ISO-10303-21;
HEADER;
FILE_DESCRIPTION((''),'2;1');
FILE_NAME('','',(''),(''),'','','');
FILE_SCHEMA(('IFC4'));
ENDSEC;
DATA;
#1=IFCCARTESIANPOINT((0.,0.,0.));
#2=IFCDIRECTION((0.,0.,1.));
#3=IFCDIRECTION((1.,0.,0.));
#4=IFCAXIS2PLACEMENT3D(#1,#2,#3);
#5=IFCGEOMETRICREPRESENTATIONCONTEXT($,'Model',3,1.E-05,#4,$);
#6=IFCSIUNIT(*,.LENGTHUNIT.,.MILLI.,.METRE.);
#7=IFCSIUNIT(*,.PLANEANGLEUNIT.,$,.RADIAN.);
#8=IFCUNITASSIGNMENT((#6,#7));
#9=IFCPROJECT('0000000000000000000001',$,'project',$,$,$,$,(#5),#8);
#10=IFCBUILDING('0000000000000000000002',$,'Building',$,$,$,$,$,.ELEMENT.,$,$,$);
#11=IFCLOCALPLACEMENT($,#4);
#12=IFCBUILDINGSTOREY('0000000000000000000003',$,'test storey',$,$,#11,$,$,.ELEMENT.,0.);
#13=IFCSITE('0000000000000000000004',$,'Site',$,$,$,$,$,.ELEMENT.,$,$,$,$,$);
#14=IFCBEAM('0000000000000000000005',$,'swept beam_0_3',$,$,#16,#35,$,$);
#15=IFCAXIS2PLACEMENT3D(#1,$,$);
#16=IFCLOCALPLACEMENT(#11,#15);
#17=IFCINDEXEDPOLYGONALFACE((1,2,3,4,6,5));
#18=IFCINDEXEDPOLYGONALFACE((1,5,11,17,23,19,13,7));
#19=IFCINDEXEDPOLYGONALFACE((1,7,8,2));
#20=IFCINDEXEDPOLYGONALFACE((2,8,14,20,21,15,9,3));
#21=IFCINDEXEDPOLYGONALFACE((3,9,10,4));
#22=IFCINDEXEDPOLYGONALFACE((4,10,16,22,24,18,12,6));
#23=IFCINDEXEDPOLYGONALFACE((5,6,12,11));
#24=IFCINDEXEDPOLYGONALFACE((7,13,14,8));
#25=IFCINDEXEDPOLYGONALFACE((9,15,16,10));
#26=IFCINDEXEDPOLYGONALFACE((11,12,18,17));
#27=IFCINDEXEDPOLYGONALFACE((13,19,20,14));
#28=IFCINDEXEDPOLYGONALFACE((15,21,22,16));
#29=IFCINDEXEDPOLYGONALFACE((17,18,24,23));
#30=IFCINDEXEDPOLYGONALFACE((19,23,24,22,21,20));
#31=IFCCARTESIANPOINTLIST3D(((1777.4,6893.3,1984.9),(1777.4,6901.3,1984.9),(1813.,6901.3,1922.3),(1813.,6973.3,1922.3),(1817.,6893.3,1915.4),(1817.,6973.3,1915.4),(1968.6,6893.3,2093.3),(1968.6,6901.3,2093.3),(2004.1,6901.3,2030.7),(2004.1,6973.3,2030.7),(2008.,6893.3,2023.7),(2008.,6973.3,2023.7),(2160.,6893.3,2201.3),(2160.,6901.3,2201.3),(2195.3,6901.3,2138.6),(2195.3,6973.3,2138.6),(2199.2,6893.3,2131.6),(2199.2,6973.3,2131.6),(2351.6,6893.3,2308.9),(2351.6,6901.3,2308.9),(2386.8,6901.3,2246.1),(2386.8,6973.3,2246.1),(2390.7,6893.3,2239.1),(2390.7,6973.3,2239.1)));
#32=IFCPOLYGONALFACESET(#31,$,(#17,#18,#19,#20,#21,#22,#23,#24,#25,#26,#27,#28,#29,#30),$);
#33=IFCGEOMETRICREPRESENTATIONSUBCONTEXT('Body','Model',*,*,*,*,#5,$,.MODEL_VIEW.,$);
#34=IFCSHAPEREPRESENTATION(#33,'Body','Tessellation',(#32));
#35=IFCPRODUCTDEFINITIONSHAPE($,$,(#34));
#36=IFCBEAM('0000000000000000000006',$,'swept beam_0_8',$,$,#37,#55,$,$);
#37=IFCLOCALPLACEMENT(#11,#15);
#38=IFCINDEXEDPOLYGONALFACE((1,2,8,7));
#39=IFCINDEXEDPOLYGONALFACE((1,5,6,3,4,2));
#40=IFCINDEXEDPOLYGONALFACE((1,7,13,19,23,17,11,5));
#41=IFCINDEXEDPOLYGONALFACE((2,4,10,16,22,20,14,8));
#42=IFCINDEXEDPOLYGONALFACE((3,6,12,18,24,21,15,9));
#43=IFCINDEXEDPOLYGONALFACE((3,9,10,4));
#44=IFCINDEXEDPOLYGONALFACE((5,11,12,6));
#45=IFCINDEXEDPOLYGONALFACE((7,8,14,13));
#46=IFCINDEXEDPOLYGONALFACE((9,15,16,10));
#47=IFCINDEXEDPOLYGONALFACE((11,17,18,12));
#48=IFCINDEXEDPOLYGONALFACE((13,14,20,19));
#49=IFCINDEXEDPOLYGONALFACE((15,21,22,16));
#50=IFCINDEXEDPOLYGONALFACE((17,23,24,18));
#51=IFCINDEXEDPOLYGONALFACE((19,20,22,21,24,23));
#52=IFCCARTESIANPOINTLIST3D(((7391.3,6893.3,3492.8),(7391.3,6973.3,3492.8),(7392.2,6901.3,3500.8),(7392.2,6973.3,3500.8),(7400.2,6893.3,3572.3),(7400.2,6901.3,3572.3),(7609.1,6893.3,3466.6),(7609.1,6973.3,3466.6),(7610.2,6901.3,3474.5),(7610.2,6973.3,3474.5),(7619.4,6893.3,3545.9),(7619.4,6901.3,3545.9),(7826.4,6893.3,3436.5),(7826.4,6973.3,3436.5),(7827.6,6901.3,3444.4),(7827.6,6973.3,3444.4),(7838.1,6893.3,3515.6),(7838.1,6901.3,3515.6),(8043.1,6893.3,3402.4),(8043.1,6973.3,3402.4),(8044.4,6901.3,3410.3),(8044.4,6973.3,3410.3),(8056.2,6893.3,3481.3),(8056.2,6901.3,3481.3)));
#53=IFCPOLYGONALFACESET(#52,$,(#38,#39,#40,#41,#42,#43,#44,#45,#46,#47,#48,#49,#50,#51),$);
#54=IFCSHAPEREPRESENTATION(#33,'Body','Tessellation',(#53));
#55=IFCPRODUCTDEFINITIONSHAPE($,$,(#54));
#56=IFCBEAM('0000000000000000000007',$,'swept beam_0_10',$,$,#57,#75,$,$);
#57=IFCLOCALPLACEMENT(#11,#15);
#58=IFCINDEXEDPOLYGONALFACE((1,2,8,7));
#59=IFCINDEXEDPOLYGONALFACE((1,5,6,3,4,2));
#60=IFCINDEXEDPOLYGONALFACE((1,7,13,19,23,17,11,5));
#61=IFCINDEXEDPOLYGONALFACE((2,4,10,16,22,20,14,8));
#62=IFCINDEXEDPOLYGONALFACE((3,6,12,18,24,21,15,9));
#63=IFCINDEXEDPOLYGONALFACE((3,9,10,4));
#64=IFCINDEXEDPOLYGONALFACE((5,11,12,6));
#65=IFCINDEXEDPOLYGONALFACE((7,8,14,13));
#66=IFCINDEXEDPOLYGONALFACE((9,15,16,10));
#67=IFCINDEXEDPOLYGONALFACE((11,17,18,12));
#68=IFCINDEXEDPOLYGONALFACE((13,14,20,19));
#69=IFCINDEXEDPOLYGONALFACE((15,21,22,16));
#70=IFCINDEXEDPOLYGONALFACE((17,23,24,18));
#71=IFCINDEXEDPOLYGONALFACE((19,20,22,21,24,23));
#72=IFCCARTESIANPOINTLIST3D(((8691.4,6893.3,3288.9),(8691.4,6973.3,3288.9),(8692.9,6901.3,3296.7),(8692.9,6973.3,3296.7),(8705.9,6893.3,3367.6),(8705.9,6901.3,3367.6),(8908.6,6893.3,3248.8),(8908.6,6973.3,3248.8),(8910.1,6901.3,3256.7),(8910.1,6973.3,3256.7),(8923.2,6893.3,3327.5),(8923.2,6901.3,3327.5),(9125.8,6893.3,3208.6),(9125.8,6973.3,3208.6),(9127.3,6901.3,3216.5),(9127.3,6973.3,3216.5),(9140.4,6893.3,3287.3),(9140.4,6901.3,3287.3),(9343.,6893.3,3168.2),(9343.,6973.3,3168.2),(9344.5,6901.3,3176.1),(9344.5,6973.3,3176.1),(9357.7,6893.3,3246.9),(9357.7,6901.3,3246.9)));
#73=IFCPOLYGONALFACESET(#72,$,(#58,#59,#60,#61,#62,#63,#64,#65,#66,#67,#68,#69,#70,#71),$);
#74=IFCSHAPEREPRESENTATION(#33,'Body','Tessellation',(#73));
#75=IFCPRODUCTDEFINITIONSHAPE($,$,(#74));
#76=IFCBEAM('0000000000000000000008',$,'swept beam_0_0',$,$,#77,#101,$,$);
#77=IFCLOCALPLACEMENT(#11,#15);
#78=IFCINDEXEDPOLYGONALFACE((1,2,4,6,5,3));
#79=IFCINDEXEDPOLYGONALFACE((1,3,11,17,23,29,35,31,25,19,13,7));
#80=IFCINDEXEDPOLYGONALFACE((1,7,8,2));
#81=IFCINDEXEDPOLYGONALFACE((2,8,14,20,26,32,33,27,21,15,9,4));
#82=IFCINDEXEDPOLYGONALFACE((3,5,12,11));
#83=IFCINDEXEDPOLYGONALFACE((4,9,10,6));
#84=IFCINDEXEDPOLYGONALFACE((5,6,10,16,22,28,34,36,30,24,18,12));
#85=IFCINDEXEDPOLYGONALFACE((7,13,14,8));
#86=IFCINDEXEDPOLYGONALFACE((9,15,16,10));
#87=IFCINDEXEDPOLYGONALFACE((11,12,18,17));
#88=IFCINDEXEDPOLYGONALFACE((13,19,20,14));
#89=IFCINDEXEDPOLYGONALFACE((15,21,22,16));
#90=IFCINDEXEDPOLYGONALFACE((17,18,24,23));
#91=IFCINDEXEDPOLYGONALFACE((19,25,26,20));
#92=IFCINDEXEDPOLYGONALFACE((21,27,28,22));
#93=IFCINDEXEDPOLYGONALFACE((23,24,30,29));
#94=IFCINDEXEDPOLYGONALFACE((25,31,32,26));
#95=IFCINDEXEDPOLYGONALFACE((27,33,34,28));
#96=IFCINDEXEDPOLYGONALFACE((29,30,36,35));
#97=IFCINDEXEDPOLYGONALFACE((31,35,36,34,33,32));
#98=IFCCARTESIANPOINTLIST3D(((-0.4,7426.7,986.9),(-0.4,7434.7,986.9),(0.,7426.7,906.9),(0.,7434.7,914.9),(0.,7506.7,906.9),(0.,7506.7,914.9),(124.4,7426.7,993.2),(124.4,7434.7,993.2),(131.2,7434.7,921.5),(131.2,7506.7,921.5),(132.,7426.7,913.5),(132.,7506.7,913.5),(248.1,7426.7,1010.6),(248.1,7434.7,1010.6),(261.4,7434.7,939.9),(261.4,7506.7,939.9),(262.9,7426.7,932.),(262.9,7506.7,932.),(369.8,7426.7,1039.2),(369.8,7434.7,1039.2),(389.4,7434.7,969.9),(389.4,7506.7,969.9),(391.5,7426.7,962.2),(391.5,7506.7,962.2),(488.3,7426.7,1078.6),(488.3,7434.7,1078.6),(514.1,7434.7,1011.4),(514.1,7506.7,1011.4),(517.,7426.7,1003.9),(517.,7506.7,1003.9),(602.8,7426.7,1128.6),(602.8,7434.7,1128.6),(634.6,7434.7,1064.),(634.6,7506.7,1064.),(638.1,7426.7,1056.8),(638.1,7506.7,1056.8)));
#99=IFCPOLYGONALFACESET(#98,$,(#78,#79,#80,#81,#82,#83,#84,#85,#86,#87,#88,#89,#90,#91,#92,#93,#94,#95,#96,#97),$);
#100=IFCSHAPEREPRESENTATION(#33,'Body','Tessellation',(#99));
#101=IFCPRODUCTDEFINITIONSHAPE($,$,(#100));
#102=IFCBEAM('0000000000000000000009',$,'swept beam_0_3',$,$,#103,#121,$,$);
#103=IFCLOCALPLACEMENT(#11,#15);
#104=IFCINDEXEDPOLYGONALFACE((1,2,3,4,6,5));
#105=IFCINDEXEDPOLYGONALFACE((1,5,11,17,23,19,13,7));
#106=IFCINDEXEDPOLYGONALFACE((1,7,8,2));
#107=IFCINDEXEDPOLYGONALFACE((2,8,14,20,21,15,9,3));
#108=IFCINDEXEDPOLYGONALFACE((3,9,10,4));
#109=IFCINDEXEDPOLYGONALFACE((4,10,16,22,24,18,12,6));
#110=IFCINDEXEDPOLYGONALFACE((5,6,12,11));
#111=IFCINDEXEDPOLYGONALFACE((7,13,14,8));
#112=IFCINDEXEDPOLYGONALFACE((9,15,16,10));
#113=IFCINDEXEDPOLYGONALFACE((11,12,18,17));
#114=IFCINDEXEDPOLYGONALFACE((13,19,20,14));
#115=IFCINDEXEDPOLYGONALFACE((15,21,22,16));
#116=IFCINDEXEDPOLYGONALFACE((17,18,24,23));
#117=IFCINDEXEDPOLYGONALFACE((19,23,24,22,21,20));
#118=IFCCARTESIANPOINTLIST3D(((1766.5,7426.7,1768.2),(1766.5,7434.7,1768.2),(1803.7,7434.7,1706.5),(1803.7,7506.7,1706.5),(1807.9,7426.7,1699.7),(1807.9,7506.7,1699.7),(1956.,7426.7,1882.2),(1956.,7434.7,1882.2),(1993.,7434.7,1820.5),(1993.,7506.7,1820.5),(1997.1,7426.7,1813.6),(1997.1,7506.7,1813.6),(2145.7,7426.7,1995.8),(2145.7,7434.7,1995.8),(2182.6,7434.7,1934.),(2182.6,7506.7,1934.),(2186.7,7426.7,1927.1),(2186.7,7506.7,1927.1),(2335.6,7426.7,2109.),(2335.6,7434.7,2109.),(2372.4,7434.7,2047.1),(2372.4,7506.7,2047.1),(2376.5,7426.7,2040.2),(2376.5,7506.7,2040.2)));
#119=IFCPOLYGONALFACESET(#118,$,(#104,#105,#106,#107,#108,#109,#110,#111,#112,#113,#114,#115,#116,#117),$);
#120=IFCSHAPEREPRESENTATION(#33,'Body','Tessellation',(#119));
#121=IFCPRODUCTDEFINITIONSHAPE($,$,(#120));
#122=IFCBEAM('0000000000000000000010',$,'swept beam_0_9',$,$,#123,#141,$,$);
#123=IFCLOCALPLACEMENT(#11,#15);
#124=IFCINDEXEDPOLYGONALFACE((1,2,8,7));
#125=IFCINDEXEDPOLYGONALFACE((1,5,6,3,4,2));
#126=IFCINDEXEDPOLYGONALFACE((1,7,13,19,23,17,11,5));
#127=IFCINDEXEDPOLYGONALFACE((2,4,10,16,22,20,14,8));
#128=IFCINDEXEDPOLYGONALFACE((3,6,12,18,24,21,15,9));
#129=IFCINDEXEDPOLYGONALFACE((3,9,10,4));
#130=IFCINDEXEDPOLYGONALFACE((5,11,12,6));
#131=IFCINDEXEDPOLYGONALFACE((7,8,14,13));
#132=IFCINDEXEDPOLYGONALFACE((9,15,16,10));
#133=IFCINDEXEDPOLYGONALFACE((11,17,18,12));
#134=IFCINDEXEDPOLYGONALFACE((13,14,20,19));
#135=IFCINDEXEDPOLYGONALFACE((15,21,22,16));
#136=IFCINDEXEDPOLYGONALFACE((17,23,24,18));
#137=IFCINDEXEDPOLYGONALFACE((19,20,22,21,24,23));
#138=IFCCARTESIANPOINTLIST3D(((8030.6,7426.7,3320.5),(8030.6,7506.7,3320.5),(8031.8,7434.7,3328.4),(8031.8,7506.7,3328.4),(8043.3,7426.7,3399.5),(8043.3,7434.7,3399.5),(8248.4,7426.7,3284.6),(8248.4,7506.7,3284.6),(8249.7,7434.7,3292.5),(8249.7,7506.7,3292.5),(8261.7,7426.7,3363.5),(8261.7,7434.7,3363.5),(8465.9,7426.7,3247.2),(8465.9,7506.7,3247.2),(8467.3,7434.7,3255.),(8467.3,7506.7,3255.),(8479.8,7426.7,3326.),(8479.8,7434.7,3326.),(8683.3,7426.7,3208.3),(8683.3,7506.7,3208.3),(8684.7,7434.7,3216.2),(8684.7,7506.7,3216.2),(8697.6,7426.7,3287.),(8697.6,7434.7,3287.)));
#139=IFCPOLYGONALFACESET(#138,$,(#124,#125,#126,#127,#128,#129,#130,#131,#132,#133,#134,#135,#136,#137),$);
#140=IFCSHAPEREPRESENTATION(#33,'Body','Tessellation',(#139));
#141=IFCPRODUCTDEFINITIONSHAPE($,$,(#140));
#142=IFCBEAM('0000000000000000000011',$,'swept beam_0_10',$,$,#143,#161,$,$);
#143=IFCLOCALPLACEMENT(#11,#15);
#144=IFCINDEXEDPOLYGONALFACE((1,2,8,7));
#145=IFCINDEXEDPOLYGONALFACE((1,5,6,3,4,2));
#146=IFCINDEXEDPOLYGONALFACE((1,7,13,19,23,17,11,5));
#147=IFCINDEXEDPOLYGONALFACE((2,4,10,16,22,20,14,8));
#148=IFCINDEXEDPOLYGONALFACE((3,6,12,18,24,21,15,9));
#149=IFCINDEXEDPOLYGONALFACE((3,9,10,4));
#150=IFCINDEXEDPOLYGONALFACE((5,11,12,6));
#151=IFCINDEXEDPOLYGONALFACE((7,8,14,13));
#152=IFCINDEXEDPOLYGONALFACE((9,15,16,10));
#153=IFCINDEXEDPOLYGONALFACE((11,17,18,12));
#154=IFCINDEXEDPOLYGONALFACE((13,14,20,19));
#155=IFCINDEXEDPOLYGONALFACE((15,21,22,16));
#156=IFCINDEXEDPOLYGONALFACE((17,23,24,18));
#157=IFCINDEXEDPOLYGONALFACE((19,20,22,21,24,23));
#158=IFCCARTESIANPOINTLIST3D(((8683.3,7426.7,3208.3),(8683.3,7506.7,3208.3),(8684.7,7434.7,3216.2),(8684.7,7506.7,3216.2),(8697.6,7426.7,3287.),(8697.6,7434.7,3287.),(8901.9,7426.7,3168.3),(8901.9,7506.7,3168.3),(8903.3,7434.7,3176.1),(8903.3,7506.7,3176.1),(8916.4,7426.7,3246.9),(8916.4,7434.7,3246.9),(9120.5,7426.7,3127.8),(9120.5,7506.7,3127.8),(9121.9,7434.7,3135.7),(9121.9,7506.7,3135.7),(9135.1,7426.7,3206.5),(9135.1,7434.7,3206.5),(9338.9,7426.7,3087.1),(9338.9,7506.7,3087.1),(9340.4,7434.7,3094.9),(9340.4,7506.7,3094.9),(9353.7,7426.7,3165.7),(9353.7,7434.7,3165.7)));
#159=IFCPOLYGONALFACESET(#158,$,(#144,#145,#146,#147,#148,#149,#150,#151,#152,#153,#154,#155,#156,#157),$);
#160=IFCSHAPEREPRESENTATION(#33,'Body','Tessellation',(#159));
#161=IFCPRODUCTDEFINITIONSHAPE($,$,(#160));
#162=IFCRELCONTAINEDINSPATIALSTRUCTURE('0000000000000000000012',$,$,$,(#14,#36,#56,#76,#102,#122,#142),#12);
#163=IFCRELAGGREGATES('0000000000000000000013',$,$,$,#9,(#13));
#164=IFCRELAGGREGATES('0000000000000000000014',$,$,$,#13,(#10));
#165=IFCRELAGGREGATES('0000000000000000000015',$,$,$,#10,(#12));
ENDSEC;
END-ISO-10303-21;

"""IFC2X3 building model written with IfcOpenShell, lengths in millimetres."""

from ifc_helpers import new_model, entity, si_unit, origin_with_axes, place, context, subcontext, project, spatial, element, save


model = new_model("IFC2X3")

# Units and contexts
model_context = context("Model", 3, precision=1e-05, world=origin_with_axes())
body_context = subcontext(model_context, "Body", "Model", "MODEL_VIEW")
ifc_project = project(units=[si_unit("LENGTHUNIT", "METRE", prefix="MILLI"), si_unit("PLANEANGLEUNIT", "RADIAN")], contexts=[model_context])

# Site, building, storey
site = spatial("IfcSite", under=ifc_project, Name="Site", CompositionType="ELEMENT")
building = spatial("IfcBuilding", under=site, Name="Building", CompositionType="ELEMENT")
storey_placement = place(None, origin_with_axes())
storey = spatial("IfcBuildingStorey", under=building, at=storey_placement, Name="test storey", CompositionType="ELEMENT", Elevation=0.0)

# Beams
beam_1_placement = place(storey_placement, origin_with_axes())
element("IfcBeam", 1, at=beam_1_placement, inside=storey, Name="swept beam_0_3", context=body_context, shape_type="SweptSolid", body=[
    entity("IfcRevolvedAreaSolid", entity("IfcArbitraryClosedProfileDef", "AREA", None, entity("IfcPolyline", [entity("IfcCartesianPoint", [80.0, -40.0]), entity("IfcCartesianPoint", [80.0, -32.0]), entity("IfcCartesianPoint", [8.0, -32.0]), entity("IfcCartesianPoint", [8.0, 40.0]), entity("IfcCartesianPoint", [0.0, 40.0]), entity("IfcCartesianPoint", [0.0, -40.0]), entity("IfcCartesianPoint", [80.0, -40.0])])), entity("IfcAxis2Placement3D", entity("IfcCartesianPoint", [1817.0, 6933.3, 1915.4]), entity("IfcDirection", [-0.8693, 0.0, -0.4943]), entity("IfcDirection", [-0.4943, 0.0, 0.8693])), entity("IfcAxis1Placement", entity("IfcCartesianPoint", [-100119.5, 0.0, 0.0]), entity("IfcDirection", [0.0, 1.0, 0.0])), 0.00658),
])
beam_2_placement = place(storey_placement, origin_with_axes())
element("IfcBeam", 2, at=beam_2_placement, inside=storey, Name="swept beam_0_8", context=body_context, shape_type="SweptSolid", body=[
    entity("IfcRevolvedAreaSolid", entity("IfcArbitraryClosedProfileDef", "AREA", None, entity("IfcPolyline", [entity("IfcCartesianPoint", [80.0, -40.0]), entity("IfcCartesianPoint", [80.0, -32.0]), entity("IfcCartesianPoint", [8.0, -32.0]), entity("IfcCartesianPoint", [8.0, 40.0]), entity("IfcCartesianPoint", [0.0, 40.0]), entity("IfcCartesianPoint", [0.0, -40.0]), entity("IfcCartesianPoint", [80.0, -40.0])])), entity("IfcAxis2Placement3D", entity("IfcCartesianPoint", [7391.3, 6933.3, 3492.8]), entity("IfcDirection", [-0.9938, 0.0, 0.1107]), entity("IfcDirection", [0.1107, 0.0, 0.9938])), entity("IfcAxis1Placement", entity("IfcCartesianPoint", [-12227.9, 0.0, 0.0]), entity("IfcDirection", [0.0, 1.0, 0.0])), 0.053816),
])
beam_3_placement = place(storey_placement, origin_with_axes())
element("IfcBeam", 3, at=beam_3_placement, inside=storey, Name="swept beam_0_10", context=body_context, shape_type="SweptSolid", body=[
    entity("IfcRevolvedAreaSolid", entity("IfcArbitraryClosedProfileDef", "AREA", None, entity("IfcPolyline", [entity("IfcCartesianPoint", [80.0, -40.0]), entity("IfcCartesianPoint", [80.0, -32.0]), entity("IfcCartesianPoint", [8.0, -32.0]), entity("IfcCartesianPoint", [8.0, 40.0]), entity("IfcCartesianPoint", [0.0, 40.0]), entity("IfcCartesianPoint", [0.0, -40.0]), entity("IfcCartesianPoint", [80.0, -40.0])])), entity("IfcAxis2Placement3D", entity("IfcCartesianPoint", [8691.4, 6933.3, 3288.9]), entity("IfcDirection", [-0.9835, 0.0, 0.1809]), entity("IfcDirection", [0.1809, 0.0, 0.9835])), entity("IfcAxis1Placement", entity("IfcCartesianPoint", [-280767.8, 0.0, 0.0]), entity("IfcDirection", [0.0, 1.0, 0.0])), 0.00236),
])
beam_4_placement = place(storey_placement, origin_with_axes())
element("IfcBeam", 4, at=beam_4_placement, inside=storey, Name="swept beam_0_0", context=body_context, shape_type="SweptSolid", body=[
    entity("IfcRevolvedAreaSolid", entity("IfcArbitraryClosedProfileDef", "AREA", None, entity("IfcPolyline", [entity("IfcCartesianPoint", [-80.0, 40.0]), entity("IfcCartesianPoint", [-80.0, 32.0]), entity("IfcCartesianPoint", [-8.0, 32.0]), entity("IfcCartesianPoint", [-8.0, -40.0]), entity("IfcCartesianPoint", [0.0, -40.0]), entity("IfcCartesianPoint", [0.0, 40.0]), entity("IfcCartesianPoint", [-80.0, 40.0])])), entity("IfcAxis2Placement3D", entity("IfcCartesianPoint", [0.0, 7466.7, 906.9]), entity("IfcDirection", [-1.0, 0.0, -0.0046]), entity("IfcDirection", [0.0046, 0.0, -1.0])), entity("IfcAxis1Placement", entity("IfcCartesianPoint", [-1462.1, 0.0, 0.0]), entity("IfcDirection", [0.0, 1.0, 0.0])), 0.452154),
])
beam_5_placement = place(storey_placement, origin_with_axes())
element("IfcBeam", 5, at=beam_5_placement, inside=storey, Name="swept beam_0_3", context=body_context, shape_type="SweptSolid", body=[
    entity("IfcRevolvedAreaSolid", entity("IfcArbitraryClosedProfileDef", "AREA", None, entity("IfcPolyline", [entity("IfcCartesianPoint", [80.0, -40.0]), entity("IfcCartesianPoint", [80.0, -32.0]), entity("IfcCartesianPoint", [8.0, -32.0]), entity("IfcCartesianPoint", [8.0, 40.0]), entity("IfcCartesianPoint", [0.0, 40.0]), entity("IfcCartesianPoint", [0.0, -40.0]), entity("IfcCartesianPoint", [80.0, -40.0])])), entity("IfcAxis2Placement3D", entity("IfcCartesianPoint", [1807.9, 7466.7, 1699.7]), entity("IfcDirection", [-0.8562, 0.0, -0.5167]), entity("IfcDirection", [-0.5167, 0.0, 0.8562])), entity("IfcAxis1Placement", entity("IfcCartesianPoint", [-96845.7, 0.0, 0.0]), entity("IfcDirection", [0.0, 1.0, 0.0])), 0.006844),
])
beam_6_placement = place(storey_placement, origin_with_axes())
element("IfcBeam", 6, at=beam_6_placement, inside=storey, Name="swept beam_0_9", context=body_context, shape_type="SweptSolid", body=[
    entity("IfcRevolvedAreaSolid", entity("IfcArbitraryClosedProfileDef", "AREA", None, entity("IfcPolyline", [entity("IfcCartesianPoint", [80.0, -40.0]), entity("IfcCartesianPoint", [80.0, -32.0]), entity("IfcCartesianPoint", [8.0, -32.0]), entity("IfcCartesianPoint", [8.0, 40.0]), entity("IfcCartesianPoint", [0.0, 40.0]), entity("IfcCartesianPoint", [0.0, -40.0]), entity("IfcCartesianPoint", [80.0, -40.0])])), entity("IfcAxis2Placement3D", entity("IfcCartesianPoint", [8030.6, 7466.7, 3320.5]), entity("IfcDirection", [-0.9872, 0.0, 0.1596]), entity("IfcDirection", [0.1596, 0.0, 0.9872])), entity("IfcAxis1Placement", entity("IfcCartesianPoint", [-33169.4, 0.0, 0.0]), entity("IfcDirection", [0.0, 1.0, 0.0])), 0.019967),
])
beam_7_placement = place(storey_placement, origin_with_axes())
element("IfcBeam", 7, at=beam_7_placement, inside=storey, Name="swept beam_0_10", context=body_context, shape_type="SweptSolid", body=[
    entity("IfcRevolvedAreaSolid", entity("IfcArbitraryClosedProfileDef", "AREA", None, entity("IfcPolyline", [entity("IfcCartesianPoint", [80.0, -40.0]), entity("IfcCartesianPoint", [80.0, -32.0]), entity("IfcCartesianPoint", [8.0, -32.0]), entity("IfcCartesianPoint", [8.0, 40.0]), entity("IfcCartesianPoint", [0.0, 40.0]), entity("IfcCartesianPoint", [0.0, -40.0]), entity("IfcCartesianPoint", [80.0, -40.0])])), entity("IfcAxis2Placement3D", entity("IfcCartesianPoint", [8683.3, 7466.7, 3208.3]), entity("IfcDirection", [-0.9838, 0.0, 0.1793]), entity("IfcDirection", [0.1793, 0.0, 0.9838])), entity("IfcAxis1Placement", entity("IfcCartesianPoint", [-130729.8, 0.0, 0.0]), entity("IfcDirection", [0.0, 1.0, 0.0])), 0.005101),
])

save(model, "model.ifc")
